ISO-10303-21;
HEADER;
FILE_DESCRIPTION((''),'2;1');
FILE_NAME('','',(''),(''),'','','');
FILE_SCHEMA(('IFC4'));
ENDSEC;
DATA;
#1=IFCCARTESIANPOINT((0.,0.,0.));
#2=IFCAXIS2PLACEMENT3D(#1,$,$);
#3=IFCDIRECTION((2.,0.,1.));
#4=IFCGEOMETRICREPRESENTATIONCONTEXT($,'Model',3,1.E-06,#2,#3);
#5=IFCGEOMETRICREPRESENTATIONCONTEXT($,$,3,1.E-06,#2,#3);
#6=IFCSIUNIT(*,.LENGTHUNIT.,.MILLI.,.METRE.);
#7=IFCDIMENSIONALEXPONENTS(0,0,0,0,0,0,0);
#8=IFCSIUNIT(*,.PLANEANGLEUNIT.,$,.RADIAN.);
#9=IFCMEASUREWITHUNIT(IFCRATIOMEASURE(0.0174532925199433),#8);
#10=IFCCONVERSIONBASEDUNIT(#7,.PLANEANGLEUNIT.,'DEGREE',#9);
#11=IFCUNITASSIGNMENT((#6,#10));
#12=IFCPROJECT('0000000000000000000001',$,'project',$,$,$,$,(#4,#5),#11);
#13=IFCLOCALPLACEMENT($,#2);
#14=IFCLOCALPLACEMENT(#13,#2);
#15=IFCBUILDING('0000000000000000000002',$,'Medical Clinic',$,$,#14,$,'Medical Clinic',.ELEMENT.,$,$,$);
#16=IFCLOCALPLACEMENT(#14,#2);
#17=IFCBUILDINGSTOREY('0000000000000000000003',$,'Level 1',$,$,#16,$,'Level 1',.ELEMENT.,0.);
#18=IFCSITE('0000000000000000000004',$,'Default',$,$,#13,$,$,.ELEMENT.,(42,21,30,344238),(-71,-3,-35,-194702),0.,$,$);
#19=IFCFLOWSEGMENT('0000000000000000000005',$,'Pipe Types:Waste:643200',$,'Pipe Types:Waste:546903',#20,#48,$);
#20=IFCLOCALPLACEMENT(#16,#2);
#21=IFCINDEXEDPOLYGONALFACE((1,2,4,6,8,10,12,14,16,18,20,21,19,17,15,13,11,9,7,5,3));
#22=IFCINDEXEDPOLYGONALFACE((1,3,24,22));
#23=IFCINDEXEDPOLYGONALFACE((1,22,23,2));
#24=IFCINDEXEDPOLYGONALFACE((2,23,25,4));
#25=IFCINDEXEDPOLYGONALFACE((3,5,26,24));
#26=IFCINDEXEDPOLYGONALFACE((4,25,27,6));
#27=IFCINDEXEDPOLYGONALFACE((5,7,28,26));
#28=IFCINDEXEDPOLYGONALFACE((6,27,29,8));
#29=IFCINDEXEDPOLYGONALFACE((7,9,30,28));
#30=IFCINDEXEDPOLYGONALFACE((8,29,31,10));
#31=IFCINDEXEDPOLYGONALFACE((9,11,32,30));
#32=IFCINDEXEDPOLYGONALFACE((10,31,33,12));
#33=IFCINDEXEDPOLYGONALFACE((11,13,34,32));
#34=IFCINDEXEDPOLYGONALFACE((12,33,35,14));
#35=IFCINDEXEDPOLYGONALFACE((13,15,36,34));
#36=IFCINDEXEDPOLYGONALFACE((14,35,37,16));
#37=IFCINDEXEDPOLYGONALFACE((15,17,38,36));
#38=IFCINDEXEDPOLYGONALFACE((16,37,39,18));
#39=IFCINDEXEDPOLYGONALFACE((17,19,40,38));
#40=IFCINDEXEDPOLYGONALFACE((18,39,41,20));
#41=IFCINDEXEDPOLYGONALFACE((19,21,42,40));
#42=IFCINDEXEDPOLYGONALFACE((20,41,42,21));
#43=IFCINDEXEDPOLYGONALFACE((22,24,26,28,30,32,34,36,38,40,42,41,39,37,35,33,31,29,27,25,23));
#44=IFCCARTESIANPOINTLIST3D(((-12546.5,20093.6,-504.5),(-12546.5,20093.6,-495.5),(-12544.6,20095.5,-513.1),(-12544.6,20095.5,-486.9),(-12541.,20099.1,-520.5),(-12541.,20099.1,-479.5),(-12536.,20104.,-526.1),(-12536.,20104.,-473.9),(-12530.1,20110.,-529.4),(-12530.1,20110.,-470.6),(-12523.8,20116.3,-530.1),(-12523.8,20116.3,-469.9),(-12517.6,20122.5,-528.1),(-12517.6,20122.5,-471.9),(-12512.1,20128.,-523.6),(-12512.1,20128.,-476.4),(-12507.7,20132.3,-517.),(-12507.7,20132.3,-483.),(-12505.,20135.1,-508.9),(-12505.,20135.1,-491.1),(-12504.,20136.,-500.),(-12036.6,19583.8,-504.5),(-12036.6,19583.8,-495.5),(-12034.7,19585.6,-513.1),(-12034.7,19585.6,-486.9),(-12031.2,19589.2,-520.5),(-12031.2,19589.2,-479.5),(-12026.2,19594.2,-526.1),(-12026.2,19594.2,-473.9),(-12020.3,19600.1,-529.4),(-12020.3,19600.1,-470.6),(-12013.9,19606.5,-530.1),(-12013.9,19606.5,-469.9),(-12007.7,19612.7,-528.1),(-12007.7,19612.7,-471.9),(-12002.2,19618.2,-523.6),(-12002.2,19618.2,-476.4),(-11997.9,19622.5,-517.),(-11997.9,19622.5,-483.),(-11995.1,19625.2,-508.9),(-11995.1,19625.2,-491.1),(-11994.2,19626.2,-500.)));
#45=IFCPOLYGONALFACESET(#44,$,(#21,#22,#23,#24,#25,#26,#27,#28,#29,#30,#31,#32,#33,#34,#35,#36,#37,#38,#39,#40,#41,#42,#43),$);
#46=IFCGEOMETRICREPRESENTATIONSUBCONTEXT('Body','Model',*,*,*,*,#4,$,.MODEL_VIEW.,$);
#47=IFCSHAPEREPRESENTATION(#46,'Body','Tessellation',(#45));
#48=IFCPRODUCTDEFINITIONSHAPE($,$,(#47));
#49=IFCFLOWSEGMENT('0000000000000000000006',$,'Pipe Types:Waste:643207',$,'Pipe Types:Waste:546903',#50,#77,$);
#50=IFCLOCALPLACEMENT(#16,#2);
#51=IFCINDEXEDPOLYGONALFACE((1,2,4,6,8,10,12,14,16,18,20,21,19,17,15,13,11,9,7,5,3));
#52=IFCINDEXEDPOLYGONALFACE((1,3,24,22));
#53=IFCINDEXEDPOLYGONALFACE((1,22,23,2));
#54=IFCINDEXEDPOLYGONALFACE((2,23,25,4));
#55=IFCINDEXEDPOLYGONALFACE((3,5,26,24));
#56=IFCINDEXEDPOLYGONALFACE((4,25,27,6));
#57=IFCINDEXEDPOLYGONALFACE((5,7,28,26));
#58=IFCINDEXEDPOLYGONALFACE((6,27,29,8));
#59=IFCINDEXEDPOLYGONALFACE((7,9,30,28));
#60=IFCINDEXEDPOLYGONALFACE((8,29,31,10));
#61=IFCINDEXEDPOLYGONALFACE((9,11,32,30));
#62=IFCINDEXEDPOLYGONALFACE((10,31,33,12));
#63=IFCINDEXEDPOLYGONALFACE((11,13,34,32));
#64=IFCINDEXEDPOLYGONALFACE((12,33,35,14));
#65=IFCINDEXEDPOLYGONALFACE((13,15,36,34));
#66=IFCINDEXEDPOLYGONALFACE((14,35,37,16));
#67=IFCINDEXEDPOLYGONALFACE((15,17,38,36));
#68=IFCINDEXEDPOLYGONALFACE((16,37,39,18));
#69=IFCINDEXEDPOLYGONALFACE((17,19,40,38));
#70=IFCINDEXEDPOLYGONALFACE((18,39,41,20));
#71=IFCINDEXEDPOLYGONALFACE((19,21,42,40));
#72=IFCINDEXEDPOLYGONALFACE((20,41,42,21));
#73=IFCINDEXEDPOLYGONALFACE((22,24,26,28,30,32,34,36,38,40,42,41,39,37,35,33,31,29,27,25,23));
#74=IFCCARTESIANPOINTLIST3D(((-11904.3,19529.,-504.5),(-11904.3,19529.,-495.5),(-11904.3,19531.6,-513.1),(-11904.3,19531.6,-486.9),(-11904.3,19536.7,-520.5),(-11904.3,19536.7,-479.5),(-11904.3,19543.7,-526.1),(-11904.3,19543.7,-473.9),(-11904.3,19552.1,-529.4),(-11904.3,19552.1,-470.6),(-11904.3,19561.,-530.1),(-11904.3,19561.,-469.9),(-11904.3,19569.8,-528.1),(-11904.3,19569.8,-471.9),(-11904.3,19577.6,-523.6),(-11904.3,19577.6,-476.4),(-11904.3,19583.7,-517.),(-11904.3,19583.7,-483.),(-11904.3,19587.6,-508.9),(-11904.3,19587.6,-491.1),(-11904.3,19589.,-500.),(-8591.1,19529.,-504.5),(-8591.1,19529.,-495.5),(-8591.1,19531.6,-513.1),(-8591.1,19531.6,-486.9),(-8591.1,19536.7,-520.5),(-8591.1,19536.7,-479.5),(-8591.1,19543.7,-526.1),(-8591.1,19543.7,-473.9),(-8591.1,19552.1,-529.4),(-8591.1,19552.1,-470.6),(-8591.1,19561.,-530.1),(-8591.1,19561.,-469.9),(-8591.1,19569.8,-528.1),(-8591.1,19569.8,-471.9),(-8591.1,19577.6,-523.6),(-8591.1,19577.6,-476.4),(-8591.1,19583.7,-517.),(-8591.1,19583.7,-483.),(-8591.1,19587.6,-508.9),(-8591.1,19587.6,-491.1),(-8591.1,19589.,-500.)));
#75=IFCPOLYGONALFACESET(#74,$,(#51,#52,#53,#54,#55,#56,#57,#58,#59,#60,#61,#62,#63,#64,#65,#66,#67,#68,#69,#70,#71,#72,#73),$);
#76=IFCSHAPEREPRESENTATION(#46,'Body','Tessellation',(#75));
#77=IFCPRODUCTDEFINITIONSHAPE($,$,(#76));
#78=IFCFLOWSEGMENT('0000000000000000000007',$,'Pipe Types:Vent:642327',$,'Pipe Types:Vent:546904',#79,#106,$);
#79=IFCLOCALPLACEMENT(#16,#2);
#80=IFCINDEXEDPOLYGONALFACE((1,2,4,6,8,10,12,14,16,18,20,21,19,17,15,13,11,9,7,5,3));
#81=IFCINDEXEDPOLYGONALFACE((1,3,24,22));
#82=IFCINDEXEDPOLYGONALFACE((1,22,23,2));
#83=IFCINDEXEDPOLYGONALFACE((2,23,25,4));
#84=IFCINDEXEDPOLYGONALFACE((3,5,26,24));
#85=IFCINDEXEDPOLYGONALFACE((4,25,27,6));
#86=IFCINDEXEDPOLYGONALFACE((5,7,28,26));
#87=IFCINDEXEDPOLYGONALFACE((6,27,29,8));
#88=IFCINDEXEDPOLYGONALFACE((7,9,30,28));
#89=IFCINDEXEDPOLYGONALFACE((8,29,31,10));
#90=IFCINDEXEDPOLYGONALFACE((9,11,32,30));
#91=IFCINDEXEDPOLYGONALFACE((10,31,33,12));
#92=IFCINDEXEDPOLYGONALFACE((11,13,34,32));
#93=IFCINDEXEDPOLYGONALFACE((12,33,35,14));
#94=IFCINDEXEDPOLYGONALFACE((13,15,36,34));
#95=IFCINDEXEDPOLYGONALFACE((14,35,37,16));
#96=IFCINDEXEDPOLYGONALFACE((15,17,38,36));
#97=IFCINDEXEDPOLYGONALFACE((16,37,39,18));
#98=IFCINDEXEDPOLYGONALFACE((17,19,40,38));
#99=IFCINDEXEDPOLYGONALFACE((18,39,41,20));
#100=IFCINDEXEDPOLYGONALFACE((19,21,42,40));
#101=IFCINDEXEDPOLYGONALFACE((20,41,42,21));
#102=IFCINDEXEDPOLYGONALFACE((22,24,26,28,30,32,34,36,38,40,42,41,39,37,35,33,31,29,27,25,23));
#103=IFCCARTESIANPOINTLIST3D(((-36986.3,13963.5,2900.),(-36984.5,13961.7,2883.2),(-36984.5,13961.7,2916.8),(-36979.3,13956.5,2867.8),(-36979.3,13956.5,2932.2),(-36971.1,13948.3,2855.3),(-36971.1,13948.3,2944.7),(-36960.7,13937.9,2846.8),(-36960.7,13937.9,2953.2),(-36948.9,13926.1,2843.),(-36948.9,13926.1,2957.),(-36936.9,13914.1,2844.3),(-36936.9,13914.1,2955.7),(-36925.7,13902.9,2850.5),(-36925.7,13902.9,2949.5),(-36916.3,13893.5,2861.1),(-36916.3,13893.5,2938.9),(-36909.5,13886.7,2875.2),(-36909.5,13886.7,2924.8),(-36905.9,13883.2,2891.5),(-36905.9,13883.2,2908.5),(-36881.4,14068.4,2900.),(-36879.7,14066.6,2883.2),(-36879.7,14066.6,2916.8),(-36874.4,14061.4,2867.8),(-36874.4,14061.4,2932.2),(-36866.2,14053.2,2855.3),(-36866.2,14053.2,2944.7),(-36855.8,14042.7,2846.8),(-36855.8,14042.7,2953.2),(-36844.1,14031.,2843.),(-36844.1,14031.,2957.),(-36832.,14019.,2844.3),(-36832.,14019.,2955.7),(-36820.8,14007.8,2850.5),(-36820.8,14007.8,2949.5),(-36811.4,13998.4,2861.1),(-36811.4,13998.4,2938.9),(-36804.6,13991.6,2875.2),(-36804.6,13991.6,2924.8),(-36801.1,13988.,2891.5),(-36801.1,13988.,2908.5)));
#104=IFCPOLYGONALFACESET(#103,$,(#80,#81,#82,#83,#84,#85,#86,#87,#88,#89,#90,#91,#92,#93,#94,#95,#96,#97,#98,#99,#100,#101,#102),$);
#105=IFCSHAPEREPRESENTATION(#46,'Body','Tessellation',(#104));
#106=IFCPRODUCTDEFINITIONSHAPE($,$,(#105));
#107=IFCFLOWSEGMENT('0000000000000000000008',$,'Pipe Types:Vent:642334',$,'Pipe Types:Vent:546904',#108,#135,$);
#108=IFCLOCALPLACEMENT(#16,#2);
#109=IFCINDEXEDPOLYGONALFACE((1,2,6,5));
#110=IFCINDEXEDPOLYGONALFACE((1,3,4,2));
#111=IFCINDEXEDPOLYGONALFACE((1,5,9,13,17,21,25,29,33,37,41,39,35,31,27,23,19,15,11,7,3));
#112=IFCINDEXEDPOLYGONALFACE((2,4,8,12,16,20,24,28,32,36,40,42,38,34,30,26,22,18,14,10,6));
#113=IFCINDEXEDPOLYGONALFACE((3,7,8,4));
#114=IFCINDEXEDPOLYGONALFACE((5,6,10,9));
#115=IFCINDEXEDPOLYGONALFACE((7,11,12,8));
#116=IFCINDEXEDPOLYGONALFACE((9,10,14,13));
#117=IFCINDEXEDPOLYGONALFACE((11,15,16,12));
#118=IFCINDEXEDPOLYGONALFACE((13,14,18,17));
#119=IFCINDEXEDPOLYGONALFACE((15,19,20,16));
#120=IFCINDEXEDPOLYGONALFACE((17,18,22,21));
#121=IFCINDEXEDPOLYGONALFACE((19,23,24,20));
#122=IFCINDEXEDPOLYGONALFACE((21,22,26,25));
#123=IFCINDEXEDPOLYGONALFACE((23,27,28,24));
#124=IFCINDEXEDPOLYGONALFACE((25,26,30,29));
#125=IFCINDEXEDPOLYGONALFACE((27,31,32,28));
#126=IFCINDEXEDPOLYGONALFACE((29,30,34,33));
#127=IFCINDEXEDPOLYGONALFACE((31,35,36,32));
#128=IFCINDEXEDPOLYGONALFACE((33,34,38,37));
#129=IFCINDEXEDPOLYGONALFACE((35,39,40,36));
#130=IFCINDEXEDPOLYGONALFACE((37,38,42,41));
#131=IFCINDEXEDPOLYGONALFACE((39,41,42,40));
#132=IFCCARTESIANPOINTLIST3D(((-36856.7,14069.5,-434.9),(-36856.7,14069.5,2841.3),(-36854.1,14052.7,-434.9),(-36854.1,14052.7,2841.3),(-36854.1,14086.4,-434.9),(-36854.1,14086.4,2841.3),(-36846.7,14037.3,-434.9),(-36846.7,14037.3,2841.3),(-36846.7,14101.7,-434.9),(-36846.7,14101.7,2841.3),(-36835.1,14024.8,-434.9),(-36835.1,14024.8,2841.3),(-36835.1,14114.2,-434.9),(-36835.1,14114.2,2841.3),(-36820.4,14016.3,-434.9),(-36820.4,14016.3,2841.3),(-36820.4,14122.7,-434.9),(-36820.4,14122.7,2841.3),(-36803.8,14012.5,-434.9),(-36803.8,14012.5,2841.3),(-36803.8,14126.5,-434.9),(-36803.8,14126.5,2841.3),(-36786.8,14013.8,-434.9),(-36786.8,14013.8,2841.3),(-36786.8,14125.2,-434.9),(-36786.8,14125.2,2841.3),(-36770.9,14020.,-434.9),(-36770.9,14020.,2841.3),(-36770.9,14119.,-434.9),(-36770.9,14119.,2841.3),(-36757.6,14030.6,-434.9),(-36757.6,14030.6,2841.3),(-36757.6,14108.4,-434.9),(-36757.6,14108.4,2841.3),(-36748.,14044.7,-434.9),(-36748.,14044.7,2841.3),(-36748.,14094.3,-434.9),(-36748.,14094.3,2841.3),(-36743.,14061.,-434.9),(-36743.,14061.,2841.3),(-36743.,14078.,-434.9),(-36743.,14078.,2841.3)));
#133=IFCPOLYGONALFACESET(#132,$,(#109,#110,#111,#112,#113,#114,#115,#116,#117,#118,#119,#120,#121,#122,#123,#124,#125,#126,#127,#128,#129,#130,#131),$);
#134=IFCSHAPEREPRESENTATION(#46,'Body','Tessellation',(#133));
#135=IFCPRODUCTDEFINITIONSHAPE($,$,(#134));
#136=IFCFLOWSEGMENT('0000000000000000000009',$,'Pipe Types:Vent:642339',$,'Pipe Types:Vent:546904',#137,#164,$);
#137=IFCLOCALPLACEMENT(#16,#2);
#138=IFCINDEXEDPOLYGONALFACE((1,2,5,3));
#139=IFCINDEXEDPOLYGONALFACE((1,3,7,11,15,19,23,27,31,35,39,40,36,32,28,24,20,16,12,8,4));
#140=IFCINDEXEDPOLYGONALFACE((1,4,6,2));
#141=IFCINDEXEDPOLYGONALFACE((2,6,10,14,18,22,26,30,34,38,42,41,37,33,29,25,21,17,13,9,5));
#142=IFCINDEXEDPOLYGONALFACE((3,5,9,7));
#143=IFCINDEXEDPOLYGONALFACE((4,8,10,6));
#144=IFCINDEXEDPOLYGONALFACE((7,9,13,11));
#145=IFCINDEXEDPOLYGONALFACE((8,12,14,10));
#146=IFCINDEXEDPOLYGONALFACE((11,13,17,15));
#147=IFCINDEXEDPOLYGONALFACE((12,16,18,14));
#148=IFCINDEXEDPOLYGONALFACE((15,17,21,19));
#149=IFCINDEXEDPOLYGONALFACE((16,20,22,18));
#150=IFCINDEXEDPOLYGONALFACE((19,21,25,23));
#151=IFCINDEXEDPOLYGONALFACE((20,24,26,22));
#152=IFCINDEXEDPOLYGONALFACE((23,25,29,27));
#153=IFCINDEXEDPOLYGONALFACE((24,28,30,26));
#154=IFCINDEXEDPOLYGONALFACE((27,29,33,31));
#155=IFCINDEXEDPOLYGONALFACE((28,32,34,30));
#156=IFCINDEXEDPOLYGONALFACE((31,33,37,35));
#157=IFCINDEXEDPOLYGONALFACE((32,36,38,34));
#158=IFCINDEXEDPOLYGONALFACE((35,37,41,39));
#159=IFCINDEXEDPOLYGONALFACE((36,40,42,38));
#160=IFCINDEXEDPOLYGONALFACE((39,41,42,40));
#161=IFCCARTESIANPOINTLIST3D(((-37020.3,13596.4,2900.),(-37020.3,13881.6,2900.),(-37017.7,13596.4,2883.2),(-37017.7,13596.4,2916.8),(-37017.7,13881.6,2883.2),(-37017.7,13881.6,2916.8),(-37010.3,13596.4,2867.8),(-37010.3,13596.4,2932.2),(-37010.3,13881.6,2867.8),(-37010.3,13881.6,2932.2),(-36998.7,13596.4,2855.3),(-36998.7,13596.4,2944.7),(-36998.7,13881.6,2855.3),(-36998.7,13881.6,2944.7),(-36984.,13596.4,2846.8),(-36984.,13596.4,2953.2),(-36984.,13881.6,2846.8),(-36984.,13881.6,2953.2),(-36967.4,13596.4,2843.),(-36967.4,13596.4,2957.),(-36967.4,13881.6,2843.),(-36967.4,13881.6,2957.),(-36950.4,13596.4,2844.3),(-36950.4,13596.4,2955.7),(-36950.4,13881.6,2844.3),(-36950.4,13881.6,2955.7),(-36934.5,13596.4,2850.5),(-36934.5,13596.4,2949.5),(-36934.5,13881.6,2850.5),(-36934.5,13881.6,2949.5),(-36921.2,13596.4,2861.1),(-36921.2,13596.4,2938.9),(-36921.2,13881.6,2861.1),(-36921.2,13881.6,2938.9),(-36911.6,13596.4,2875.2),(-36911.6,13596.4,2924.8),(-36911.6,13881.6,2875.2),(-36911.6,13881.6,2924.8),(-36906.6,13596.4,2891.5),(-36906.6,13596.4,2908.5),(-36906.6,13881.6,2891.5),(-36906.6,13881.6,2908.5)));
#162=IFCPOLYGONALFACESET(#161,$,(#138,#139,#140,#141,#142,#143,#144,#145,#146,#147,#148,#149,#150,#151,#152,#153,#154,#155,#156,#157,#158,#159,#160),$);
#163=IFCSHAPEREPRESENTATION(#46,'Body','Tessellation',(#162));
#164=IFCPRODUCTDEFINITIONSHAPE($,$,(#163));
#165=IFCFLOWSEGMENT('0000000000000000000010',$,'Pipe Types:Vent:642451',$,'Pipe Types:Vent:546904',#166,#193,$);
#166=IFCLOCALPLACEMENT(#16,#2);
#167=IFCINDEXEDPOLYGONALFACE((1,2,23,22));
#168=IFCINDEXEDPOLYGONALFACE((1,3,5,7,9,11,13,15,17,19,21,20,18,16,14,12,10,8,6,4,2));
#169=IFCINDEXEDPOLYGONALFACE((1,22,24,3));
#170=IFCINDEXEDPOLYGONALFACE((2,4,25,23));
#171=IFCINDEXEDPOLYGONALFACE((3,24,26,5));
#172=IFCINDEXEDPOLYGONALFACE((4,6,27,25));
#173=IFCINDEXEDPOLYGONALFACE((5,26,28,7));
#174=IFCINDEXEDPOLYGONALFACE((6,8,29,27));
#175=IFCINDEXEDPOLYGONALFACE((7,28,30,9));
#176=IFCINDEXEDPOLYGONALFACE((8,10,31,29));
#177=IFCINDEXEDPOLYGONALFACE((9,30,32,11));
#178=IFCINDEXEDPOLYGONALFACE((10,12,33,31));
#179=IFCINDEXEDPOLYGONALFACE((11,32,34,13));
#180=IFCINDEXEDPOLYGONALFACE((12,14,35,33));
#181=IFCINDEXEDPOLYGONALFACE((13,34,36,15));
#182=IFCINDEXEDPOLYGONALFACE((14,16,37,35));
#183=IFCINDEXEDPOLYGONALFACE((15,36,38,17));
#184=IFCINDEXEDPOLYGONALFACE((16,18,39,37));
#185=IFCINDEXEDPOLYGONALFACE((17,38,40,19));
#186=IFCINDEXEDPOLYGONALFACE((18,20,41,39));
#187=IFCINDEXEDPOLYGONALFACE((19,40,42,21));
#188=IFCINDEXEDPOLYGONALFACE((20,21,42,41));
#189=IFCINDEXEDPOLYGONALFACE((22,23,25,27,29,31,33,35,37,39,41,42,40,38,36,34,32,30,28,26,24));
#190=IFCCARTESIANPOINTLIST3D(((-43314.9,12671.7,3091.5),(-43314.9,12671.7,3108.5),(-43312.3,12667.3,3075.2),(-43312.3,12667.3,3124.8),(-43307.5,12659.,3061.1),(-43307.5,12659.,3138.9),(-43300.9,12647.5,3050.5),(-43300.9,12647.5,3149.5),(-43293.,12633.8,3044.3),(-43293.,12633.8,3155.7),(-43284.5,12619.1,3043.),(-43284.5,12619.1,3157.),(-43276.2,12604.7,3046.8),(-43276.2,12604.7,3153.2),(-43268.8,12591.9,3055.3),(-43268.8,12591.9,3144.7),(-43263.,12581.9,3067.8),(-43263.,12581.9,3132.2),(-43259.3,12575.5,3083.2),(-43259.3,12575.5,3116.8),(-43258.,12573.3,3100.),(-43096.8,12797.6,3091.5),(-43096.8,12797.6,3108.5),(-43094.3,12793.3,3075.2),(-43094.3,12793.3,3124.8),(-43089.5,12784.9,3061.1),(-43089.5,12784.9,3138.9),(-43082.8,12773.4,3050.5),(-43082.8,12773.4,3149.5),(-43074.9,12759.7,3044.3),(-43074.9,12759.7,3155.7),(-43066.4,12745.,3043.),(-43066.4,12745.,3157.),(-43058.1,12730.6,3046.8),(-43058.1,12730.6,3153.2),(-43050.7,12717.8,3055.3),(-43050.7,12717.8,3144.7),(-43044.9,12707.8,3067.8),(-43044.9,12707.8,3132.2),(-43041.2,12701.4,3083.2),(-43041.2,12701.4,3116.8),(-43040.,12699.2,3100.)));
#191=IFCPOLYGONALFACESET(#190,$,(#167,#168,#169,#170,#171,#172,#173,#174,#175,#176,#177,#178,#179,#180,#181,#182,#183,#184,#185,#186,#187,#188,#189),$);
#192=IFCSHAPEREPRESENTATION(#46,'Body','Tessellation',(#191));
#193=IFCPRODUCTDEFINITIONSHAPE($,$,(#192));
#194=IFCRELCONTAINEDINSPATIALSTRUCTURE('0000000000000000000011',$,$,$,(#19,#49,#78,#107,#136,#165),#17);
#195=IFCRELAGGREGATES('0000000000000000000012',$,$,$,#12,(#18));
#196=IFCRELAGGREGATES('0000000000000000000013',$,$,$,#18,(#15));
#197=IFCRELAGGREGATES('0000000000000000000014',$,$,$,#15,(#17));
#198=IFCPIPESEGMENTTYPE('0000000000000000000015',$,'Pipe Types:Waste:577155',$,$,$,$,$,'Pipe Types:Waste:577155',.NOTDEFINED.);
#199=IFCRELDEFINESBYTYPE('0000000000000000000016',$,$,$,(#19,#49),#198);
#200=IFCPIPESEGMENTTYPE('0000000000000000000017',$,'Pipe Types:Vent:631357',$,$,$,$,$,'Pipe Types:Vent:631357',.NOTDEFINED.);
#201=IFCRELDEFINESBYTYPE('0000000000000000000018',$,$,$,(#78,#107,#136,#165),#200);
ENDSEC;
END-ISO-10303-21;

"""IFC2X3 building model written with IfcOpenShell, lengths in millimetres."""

from ifc_helpers import new_model, entity, si_unit, converted_unit, direction, frame, frame_2d, origin, origin_2d_with_axis, place, context, subcontext, project, spatial, circle, extrude, type_object, element, save


model = new_model("IFC2X3")

# Units and contexts
model_context = context("Model", 3, precision=1e-06, world=origin(), true_north=direction((2.0, 0.0, 1.0)))
context_of_model = context(None, 3, precision=1e-06, world=origin(), true_north=direction((2.0, 0.0, 1.0)))
body_context = subcontext(model_context, "Body", "Model", "MODEL_VIEW")
ifc_project = project(units=[si_unit("LENGTHUNIT", "METRE", prefix="MILLI"), converted_unit("PLANEANGLEUNIT", "DEGREE", entity("IfcRatioMeasure", 0.0174532925199433), si_unit("PLANEANGLEUNIT", "RADIAN"), dimensions=[0, 0, 0, 0, 0, 0, 0])], contexts=[model_context, context_of_model])

# Site, building, storey
site_placement = place(None, origin())
site = spatial("IfcSite", under=ifc_project, at=site_placement, Name="Default", CompositionType="ELEMENT", RefLatitude=(42, 21, 30, 344238), RefLongitude=(-71, -3, -35, -194702), RefElevation=0.0)
building_placement = place(site_placement, origin())
building = spatial("IfcBuilding", under=site, at=building_placement, Name="Medical Clinic", LongName="Medical Clinic", CompositionType="ELEMENT")
storey_placement = place(building_placement, origin())
storey = spatial("IfcBuildingStorey", under=building, at=storey_placement, Name="Level 1", LongName="Level 1", CompositionType="ELEMENT", Elevation=0.0)

# Flow segments
pipe_segment_type_1 = type_object("IfcPipeSegmentType", Name="Pipe Types:Waste:577155", ElementType="Pipe Types:Waste:577155", PredefinedType="NOTDEFINED")
flow_segment_1_placement = place(storey_placement, origin())
element("IfcFlowSegment", 1, at=flow_segment_1_placement, inside=storey, type_object=pipe_segment_type_1, Name="Pipe Types:Waste:643200", ObjectType="Pipe Types:Waste:546903", context=body_context, shape_type="SweptSolid", body=[
    extrude(circle(Radius=30.2, at=frame_2d((0.0, 0.0), x_axis=(1.0, 0.0))), frame((-12525.4, 20114.7, -500.0), z_axis=(0.707107, -0.707107, 0.0), x_axis=(0.707107, 0.707107, 0.0)), (0.0, 0.0, 1.0), 721.0),
])
flow_segment_2_placement = place(storey_placement, origin())
element("IfcFlowSegment", 2, at=flow_segment_2_placement, inside=storey, type_object=pipe_segment_type_1, Name="Pipe Types:Waste:643207", ObjectType="Pipe Types:Waste:546903", context=body_context, shape_type="SweptSolid", body=[
    extrude(circle(Radius=30.2, at=frame_2d((0.0, 0.0), x_axis=(1.0, 0.0))), frame((-11904.3, 19558.8, -500.0), z_axis=(1.0, 0.0, 0.0), x_axis=(0.0, 1.0, 0.0)), (0.0, 0.0, 1.0), 3313.2),
])
pipe_segment_type_2 = type_object("IfcPipeSegmentType", Name="Pipe Types:Vent:631357", ElementType="Pipe Types:Vent:631357", PredefinedType="NOTDEFINED")
flow_segment_3_placement = place(storey_placement, origin())
element("IfcFlowSegment", 3, at=flow_segment_3_placement, inside=storey, type_object=pipe_segment_type_2, Name="Pipe Types:Vent:642327", ObjectType="Pipe Types:Vent:546904", context=body_context, shape_type="SweptSolid", body=[
    extrude(circle(Radius=57.1, at=origin_2d_with_axis()), frame((-36945.9, 13923.1, 2900.0), z_axis=(0.707107, 0.707107, 0.0), x_axis=(-0.707107, 0.707107, 0.0)), (0.0, 0.0, 1.0), 148.3),
])
flow_segment_4_placement = place(storey_placement, origin())
element("IfcFlowSegment", 4, at=flow_segment_4_placement, inside=storey, type_object=pipe_segment_type_2, Name="Pipe Types:Vent:642334", ObjectType="Pipe Types:Vent:546904", context=body_context, shape_type="SweptSolid", body=[
    extrude(circle(Radius=57.1, at=origin_2d_with_axis()), frame((-36799.5, 14069.5, -434.9), z_axis=(0.0, 0.0, 1.0), x_axis=(-1.0, 0.0, 0.0)), (0.0, 0.0, 1.0), 3276.2),
])
flow_segment_5_placement = place(storey_placement, origin())
element("IfcFlowSegment", 5, at=flow_segment_5_placement, inside=storey, type_object=pipe_segment_type_2, Name="Pipe Types:Vent:642339", ObjectType="Pipe Types:Vent:546904", context=body_context, shape_type="SweptSolid", body=[
    extrude(circle(Radius=57.1, at=frame_2d((0.0, 0.0), x_axis=(1.0, 0.0))), frame((-36963.1, 13596.4, 2900.0), z_axis=(0.0, 1.0, 0.0), x_axis=(-1.0, 0.0, 0.0)), (0.0, 0.0, 1.0), 285.2),
])
flow_segment_6_placement = place(storey_placement, origin())
element("IfcFlowSegment", 6, at=flow_segment_6_placement, inside=storey, type_object=pipe_segment_type_2, Name="Pipe Types:Vent:642451", ObjectType="Pipe Types:Vent:546904", context=body_context, shape_type="SweptSolid", body=[
    extrude(circle(Radius=57.1, at=origin_2d_with_axis()), frame((-43286.6, 12622.8, 3100.0), z_axis=(0.866025, 0.5, 0.0), x_axis=(0.5, -0.866025, 0.0)), (0.0, 0.0, 1.0), 251.8),
])

save(model, "model.ifc")
